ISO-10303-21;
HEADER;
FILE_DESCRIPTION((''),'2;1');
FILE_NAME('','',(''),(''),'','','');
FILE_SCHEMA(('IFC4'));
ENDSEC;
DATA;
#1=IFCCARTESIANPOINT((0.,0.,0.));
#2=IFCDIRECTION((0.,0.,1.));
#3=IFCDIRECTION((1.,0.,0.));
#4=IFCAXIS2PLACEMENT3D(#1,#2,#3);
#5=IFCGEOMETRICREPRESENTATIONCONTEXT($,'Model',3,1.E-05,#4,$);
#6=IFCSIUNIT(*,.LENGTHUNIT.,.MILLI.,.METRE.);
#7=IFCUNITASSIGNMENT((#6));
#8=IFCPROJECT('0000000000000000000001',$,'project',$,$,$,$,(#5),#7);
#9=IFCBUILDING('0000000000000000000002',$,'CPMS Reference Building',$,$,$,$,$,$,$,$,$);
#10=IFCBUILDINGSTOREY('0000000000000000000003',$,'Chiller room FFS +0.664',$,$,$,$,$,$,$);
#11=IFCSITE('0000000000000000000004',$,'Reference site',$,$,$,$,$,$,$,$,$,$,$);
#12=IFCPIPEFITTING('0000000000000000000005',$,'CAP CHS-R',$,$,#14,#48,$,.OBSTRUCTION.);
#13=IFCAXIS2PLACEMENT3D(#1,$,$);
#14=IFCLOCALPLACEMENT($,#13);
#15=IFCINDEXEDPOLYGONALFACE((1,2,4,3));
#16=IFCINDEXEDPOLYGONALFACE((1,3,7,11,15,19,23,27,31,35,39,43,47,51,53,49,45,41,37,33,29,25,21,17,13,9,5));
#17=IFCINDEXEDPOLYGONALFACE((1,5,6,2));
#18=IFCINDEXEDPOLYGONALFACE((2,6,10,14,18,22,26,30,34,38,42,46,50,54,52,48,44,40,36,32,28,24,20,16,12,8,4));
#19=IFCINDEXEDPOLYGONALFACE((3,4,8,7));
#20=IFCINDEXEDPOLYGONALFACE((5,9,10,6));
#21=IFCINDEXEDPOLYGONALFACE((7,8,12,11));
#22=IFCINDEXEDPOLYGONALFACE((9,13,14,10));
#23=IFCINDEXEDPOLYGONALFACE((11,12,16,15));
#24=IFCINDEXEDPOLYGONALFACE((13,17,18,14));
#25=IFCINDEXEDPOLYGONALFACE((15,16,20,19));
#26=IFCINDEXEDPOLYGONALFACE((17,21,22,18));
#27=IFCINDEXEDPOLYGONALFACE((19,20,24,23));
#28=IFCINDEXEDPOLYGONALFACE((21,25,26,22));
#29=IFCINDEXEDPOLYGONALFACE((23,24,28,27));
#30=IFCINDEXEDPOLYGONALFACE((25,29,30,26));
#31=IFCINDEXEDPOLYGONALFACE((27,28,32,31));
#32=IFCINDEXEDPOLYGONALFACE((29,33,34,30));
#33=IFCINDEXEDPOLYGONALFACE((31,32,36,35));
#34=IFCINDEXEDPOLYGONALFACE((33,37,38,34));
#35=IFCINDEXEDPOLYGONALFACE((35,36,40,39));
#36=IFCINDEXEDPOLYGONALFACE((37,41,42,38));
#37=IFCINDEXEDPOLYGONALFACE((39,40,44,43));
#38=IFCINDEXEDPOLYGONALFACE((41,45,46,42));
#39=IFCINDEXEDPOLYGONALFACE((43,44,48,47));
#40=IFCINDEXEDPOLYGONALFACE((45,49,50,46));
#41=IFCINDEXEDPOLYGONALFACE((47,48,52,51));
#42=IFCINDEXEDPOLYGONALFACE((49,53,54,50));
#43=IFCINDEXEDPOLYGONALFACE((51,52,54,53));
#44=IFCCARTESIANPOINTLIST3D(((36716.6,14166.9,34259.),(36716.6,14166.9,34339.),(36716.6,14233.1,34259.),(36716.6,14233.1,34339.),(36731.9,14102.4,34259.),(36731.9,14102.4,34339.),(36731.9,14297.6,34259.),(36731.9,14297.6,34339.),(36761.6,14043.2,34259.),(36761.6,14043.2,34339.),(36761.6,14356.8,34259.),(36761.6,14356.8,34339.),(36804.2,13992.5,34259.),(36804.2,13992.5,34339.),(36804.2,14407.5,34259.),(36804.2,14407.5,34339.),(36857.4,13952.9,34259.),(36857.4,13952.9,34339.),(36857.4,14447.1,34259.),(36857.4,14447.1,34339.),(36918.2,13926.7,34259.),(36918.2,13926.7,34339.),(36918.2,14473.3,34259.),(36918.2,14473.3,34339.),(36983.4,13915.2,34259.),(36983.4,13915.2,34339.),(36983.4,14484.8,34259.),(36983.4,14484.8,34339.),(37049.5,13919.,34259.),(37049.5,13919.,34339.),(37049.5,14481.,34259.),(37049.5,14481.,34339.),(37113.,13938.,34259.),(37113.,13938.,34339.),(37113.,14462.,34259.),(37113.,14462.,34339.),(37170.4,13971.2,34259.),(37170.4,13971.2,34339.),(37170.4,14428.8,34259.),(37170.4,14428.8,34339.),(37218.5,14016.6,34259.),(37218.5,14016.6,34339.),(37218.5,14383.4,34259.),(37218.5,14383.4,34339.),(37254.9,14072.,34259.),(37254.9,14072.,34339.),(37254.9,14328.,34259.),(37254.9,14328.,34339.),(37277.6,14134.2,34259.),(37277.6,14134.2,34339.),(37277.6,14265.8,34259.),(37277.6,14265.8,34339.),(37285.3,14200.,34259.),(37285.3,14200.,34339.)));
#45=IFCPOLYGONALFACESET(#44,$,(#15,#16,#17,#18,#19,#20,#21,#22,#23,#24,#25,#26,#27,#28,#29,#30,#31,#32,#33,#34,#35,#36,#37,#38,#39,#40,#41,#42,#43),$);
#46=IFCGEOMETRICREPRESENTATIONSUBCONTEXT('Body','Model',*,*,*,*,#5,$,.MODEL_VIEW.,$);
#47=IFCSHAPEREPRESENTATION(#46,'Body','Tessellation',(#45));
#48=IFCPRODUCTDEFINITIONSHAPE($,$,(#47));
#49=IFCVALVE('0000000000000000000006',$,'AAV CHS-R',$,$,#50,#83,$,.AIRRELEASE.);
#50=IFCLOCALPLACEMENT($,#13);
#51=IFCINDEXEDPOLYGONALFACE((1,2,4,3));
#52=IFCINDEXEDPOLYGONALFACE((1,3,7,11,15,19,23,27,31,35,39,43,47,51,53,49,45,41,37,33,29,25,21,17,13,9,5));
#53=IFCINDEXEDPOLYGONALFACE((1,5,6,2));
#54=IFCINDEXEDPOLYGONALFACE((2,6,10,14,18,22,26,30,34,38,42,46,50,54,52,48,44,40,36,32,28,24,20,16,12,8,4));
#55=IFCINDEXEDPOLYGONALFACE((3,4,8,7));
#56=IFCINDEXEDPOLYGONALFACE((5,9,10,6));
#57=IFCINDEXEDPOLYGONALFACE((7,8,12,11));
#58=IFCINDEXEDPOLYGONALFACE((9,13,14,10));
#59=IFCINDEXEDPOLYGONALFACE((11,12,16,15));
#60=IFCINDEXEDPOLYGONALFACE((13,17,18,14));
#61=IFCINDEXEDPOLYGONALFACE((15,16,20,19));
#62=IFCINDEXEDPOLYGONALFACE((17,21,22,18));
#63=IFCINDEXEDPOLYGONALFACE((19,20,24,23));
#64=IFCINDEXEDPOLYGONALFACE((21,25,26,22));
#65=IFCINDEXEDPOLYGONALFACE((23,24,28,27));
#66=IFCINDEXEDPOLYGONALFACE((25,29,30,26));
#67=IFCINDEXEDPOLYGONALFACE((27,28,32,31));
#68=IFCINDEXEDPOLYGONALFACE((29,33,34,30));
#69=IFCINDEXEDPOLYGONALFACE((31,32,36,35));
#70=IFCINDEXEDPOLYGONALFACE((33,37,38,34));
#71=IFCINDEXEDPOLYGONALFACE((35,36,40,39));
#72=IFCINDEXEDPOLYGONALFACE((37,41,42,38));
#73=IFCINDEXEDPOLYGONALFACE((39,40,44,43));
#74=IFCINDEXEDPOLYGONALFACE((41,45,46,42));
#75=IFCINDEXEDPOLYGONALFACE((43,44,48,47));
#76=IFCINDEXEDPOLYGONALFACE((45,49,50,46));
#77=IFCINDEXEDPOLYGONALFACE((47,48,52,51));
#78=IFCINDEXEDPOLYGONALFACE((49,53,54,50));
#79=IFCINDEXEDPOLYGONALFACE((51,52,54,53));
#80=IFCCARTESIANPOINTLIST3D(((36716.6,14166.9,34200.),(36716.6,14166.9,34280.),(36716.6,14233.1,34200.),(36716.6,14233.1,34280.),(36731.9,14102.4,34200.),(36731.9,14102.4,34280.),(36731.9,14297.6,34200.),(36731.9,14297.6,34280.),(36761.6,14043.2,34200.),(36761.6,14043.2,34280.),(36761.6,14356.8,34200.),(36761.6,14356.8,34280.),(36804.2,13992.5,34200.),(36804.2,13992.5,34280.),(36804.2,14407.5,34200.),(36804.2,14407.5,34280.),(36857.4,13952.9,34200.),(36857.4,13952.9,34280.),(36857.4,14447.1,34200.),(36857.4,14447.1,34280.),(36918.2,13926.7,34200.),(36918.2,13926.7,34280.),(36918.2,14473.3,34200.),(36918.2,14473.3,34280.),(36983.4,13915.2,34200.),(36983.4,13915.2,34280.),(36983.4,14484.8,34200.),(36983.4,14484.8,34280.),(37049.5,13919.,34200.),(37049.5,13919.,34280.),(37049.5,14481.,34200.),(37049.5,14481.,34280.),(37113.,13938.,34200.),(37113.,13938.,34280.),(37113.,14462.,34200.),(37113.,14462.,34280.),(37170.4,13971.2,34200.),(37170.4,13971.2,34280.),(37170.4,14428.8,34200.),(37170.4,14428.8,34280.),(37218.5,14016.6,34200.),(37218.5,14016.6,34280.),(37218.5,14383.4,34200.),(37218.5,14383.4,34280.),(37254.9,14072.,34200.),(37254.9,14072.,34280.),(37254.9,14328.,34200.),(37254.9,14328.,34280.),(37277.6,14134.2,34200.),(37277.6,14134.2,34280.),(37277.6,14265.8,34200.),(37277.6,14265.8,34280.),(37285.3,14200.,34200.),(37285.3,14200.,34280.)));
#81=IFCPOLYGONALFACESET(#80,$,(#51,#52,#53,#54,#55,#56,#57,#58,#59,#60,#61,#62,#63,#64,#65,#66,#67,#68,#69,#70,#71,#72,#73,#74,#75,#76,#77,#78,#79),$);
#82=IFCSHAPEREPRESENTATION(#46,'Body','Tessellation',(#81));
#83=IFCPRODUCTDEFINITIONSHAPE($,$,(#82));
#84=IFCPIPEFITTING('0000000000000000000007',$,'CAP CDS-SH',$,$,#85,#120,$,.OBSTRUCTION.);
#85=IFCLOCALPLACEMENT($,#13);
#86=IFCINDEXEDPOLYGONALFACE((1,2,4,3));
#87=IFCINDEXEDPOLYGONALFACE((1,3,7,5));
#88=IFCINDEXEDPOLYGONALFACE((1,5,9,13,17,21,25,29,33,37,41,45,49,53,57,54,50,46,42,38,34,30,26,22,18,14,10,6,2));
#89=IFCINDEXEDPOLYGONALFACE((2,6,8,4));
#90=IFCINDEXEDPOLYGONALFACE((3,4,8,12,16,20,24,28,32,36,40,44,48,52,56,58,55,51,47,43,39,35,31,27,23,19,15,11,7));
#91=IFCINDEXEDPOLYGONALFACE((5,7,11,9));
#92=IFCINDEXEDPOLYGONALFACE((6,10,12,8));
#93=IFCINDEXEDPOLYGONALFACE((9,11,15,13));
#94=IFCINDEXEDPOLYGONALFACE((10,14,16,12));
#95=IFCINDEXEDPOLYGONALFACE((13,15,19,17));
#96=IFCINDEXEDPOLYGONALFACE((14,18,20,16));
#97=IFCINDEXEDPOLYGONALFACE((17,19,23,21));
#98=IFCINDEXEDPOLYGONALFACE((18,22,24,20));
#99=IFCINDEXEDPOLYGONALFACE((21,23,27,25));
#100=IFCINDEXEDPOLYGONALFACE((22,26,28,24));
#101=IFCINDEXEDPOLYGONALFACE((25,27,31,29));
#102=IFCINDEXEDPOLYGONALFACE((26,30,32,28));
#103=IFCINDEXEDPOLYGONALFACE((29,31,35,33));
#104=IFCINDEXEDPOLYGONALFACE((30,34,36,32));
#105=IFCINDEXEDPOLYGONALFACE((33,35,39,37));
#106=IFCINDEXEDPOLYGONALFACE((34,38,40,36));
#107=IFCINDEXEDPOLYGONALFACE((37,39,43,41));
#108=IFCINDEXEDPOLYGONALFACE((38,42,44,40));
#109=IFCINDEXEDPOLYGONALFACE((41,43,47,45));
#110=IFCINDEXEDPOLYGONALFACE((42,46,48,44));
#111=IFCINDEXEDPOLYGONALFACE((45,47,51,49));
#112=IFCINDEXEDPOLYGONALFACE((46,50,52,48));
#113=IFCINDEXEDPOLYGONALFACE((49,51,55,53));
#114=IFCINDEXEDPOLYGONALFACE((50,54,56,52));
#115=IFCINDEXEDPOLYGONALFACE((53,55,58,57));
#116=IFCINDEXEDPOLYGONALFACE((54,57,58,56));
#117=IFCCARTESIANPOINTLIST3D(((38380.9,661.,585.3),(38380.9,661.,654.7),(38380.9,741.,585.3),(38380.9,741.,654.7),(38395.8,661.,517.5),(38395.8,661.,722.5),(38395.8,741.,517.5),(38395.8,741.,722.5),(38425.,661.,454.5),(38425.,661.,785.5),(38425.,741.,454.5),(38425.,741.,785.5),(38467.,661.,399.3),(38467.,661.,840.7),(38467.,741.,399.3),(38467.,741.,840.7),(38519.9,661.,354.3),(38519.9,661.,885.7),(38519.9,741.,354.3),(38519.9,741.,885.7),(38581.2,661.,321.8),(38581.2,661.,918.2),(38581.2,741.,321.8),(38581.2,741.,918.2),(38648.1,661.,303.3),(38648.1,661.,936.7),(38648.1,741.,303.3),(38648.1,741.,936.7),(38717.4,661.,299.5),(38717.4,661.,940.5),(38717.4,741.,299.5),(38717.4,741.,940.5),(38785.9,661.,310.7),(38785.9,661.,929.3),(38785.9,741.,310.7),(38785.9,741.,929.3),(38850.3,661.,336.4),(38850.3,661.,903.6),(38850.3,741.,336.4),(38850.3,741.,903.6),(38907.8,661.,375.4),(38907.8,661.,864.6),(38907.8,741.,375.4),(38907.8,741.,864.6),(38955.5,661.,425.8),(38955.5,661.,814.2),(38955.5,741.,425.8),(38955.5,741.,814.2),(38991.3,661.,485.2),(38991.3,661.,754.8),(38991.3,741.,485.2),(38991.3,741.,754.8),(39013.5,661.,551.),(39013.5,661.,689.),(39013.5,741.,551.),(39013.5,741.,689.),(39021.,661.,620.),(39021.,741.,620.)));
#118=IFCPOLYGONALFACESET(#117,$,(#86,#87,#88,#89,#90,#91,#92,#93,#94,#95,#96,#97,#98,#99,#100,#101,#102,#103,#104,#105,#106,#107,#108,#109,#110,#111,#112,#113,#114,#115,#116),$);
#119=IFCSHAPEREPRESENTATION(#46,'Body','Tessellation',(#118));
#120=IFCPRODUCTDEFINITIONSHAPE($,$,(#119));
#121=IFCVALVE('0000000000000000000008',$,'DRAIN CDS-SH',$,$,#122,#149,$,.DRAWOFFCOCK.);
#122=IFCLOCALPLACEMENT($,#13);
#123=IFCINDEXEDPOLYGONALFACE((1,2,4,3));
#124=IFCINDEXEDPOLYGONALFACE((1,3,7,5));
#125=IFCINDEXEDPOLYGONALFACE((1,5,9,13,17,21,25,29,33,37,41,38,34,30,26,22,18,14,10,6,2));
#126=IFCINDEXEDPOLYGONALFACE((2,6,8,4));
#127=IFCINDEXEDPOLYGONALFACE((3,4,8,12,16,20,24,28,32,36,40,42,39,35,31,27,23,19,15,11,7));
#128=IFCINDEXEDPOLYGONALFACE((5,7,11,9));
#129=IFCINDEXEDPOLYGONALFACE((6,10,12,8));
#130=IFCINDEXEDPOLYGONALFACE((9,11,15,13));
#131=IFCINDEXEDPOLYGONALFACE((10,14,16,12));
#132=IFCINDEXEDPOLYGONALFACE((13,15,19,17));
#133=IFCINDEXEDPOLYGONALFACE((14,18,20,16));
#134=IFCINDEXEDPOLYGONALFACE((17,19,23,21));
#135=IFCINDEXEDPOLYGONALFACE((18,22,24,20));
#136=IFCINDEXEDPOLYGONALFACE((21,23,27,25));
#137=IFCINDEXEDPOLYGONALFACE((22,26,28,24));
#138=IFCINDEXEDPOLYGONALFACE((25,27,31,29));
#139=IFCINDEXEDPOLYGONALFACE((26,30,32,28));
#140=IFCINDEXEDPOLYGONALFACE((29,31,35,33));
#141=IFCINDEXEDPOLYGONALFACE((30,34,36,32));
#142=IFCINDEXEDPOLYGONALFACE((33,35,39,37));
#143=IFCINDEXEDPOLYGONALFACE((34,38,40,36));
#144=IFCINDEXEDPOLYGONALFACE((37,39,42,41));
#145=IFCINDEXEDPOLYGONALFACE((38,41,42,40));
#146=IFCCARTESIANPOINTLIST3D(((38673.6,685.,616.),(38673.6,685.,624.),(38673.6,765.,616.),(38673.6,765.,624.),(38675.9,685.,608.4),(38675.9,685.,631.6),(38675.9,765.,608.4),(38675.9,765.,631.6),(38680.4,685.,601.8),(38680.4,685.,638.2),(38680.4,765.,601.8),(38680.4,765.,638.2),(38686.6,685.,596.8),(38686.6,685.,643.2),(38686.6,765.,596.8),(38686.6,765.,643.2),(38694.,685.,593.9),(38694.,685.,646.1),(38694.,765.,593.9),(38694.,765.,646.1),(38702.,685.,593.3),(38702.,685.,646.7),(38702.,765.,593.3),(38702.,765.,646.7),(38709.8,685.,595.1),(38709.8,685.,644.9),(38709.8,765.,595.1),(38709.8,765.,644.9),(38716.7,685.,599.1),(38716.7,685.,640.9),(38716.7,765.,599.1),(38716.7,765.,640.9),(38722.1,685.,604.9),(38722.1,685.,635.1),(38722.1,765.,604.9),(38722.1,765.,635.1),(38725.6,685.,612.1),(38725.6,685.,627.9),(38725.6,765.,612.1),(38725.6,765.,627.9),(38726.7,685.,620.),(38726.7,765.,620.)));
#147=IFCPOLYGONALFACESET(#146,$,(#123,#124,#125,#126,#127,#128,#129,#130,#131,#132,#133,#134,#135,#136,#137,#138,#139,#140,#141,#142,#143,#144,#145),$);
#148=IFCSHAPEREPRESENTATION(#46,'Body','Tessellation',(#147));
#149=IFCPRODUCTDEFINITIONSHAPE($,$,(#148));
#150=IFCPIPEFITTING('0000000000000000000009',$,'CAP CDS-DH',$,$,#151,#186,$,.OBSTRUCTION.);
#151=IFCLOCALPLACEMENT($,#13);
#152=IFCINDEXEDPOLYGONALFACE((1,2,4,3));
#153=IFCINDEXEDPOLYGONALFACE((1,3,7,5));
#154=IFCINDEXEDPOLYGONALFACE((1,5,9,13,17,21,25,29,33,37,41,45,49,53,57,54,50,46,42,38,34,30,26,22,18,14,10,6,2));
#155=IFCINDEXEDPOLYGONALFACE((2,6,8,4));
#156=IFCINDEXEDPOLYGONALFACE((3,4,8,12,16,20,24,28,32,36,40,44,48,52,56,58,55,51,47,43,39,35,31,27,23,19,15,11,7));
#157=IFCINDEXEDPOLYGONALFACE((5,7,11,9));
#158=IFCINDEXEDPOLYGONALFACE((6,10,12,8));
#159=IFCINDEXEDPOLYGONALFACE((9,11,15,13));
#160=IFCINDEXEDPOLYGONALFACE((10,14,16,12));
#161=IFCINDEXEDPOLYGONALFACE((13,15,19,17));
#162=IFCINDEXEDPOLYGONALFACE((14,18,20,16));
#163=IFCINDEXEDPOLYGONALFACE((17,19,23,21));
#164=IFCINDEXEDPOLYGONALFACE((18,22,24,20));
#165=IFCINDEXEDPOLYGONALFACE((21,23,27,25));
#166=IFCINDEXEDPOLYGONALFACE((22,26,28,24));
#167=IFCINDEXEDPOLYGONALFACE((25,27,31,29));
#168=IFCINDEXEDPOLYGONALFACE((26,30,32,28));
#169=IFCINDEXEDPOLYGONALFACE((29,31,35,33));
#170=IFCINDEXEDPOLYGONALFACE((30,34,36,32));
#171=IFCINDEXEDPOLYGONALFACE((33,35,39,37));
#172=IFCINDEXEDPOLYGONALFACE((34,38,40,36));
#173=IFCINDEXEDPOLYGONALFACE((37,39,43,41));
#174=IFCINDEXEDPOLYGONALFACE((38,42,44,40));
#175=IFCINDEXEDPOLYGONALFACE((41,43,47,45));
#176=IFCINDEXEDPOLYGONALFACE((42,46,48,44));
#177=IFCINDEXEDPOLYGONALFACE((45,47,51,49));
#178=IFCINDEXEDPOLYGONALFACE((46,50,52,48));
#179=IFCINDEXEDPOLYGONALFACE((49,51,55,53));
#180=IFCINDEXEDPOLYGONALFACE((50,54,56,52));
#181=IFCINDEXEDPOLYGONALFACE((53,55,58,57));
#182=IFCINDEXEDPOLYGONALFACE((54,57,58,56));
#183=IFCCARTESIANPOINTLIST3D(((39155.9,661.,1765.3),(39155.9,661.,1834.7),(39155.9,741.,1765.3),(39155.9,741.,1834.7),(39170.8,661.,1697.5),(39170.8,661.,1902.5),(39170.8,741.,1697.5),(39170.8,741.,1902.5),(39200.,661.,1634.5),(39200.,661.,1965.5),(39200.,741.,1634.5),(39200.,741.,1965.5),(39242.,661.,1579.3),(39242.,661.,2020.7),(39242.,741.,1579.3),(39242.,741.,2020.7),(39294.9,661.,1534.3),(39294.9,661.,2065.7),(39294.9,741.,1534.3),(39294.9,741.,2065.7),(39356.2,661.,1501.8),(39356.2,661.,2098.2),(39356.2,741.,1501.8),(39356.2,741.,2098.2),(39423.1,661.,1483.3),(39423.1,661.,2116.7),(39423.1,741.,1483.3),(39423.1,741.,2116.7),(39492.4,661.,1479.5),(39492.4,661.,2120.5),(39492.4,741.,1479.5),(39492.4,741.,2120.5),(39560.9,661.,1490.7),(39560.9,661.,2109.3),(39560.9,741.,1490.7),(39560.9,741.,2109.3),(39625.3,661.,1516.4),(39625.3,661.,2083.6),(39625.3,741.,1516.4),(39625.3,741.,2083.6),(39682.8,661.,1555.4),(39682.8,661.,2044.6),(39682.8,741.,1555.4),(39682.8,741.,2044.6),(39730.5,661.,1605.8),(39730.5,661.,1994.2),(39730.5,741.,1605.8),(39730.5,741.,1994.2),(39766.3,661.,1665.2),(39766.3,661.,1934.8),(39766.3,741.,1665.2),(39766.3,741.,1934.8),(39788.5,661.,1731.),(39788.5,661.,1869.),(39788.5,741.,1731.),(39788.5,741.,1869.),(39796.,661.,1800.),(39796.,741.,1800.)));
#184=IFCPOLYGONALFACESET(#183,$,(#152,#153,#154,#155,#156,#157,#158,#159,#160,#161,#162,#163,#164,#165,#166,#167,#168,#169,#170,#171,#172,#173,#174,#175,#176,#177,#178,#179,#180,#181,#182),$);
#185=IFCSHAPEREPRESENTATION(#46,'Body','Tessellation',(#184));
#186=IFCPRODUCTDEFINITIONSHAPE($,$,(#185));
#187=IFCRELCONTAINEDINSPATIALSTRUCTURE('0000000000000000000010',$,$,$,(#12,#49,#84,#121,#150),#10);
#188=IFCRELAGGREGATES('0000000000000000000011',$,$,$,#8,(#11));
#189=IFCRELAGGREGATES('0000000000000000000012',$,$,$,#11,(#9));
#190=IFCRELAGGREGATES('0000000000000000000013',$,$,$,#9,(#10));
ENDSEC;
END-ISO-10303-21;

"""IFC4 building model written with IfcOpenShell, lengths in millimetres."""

from ifc_helpers import new_model, si_unit, frame, origin_with_axes, origin_2d, place, context, subcontext, project, spatial, circle_curve, outline, extrude, element, save


model = new_model("IFC4")

# Units and contexts
model_context = context("Model", 3, precision=1e-05, world=origin_with_axes())
body_context = subcontext(model_context, "Body", "Model", "MODEL_VIEW")
ifc_project = project(units=[si_unit("LENGTHUNIT", "METRE", prefix="MILLI")], contexts=[model_context])

# Site, building, storey
site = spatial("IfcSite", under=ifc_project, Name="Reference site")
building = spatial("IfcBuilding", under=site, Name="CPMS Reference Building")
storey = spatial("IfcBuildingStorey", under=building, Name="Chiller room FFS +0.664")

# Pipe fitting
pipe_fitting_1_placement = place(None, origin_with_axes())
element("IfcPipeFitting", 1, at=pipe_fitting_1_placement, inside=storey, Name="CAP CHS-R", PredefinedType="OBSTRUCTION", context=body_context, shape_type="SweptSolid", body=[
    extrude(outline(circle_curve(origin_2d(), 285.3)), frame((37000.0, 14200.0, 34259.0), z_axis=(0.0, 0.0, 1.0), x_axis=(1.0, 0.0, 0.0)), (0.0, 0.0, 1.0), 80.0),
])

# Valve
valve_1_placement = place(None, origin_with_axes())
element("IfcValve", 2, at=valve_1_placement, inside=storey, Name="AAV CHS-R", PredefinedType="AIRRELEASE", context=body_context, shape_type="SweptSolid", body=[
    extrude(outline(circle_curve(origin_2d(), 285.3)), frame((37000.0, 14200.0, 34200.0), z_axis=(0.0, 0.0, 1.0), x_axis=(1.0, 0.0, 0.0)), (0.0, 0.0, 1.0), 80.0),
])

# Pipe fitting
pipe_fitting_2_placement = place(None, origin_with_axes())
element("IfcPipeFitting", 3, at=pipe_fitting_2_placement, inside=storey, Name="CAP CDS-SH", PredefinedType="OBSTRUCTION", context=body_context, shape_type="SweptSolid", body=[
    extrude(outline(circle_curve(origin_2d(), 321.0)), frame((38700.0, 741.0, 620.0), z_axis=(0.0, -1.0, 0.0), x_axis=(1.0, 0.0, 0.0)), (0.0, 0.0, 1.0), 80.0),
])

# Valve
valve_2_placement = place(None, origin_with_axes())
element("IfcValve", 4, at=valve_2_placement, inside=storey, Name="DRAIN CDS-SH", PredefinedType="DRAWOFFCOCK", context=body_context, shape_type="SweptSolid", body=[
    extrude(outline(circle_curve(origin_2d(), 26.7)), frame((38700.0, 765.0, 620.0), z_axis=(0.0, -1.0, 0.0), x_axis=(1.0, 0.0, 0.0)), (0.0, 0.0, 1.0), 80.0),
])

# Pipe fitting
pipe_fitting_3_placement = place(None, origin_with_axes())
element("IfcPipeFitting", 5, at=pipe_fitting_3_placement, inside=storey, Name="CAP CDS-DH", PredefinedType="OBSTRUCTION", context=body_context, shape_type="SweptSolid", body=[
    extrude(outline(circle_curve(origin_2d(), 321.0)), frame((39475.0, 661.0, 1800.0), z_axis=(0.0, 1.0, 0.0), x_axis=(1.0, 0.0, 0.0)), (0.0, 0.0, 1.0), 80.0),
])

save(model, "model.ifc")
